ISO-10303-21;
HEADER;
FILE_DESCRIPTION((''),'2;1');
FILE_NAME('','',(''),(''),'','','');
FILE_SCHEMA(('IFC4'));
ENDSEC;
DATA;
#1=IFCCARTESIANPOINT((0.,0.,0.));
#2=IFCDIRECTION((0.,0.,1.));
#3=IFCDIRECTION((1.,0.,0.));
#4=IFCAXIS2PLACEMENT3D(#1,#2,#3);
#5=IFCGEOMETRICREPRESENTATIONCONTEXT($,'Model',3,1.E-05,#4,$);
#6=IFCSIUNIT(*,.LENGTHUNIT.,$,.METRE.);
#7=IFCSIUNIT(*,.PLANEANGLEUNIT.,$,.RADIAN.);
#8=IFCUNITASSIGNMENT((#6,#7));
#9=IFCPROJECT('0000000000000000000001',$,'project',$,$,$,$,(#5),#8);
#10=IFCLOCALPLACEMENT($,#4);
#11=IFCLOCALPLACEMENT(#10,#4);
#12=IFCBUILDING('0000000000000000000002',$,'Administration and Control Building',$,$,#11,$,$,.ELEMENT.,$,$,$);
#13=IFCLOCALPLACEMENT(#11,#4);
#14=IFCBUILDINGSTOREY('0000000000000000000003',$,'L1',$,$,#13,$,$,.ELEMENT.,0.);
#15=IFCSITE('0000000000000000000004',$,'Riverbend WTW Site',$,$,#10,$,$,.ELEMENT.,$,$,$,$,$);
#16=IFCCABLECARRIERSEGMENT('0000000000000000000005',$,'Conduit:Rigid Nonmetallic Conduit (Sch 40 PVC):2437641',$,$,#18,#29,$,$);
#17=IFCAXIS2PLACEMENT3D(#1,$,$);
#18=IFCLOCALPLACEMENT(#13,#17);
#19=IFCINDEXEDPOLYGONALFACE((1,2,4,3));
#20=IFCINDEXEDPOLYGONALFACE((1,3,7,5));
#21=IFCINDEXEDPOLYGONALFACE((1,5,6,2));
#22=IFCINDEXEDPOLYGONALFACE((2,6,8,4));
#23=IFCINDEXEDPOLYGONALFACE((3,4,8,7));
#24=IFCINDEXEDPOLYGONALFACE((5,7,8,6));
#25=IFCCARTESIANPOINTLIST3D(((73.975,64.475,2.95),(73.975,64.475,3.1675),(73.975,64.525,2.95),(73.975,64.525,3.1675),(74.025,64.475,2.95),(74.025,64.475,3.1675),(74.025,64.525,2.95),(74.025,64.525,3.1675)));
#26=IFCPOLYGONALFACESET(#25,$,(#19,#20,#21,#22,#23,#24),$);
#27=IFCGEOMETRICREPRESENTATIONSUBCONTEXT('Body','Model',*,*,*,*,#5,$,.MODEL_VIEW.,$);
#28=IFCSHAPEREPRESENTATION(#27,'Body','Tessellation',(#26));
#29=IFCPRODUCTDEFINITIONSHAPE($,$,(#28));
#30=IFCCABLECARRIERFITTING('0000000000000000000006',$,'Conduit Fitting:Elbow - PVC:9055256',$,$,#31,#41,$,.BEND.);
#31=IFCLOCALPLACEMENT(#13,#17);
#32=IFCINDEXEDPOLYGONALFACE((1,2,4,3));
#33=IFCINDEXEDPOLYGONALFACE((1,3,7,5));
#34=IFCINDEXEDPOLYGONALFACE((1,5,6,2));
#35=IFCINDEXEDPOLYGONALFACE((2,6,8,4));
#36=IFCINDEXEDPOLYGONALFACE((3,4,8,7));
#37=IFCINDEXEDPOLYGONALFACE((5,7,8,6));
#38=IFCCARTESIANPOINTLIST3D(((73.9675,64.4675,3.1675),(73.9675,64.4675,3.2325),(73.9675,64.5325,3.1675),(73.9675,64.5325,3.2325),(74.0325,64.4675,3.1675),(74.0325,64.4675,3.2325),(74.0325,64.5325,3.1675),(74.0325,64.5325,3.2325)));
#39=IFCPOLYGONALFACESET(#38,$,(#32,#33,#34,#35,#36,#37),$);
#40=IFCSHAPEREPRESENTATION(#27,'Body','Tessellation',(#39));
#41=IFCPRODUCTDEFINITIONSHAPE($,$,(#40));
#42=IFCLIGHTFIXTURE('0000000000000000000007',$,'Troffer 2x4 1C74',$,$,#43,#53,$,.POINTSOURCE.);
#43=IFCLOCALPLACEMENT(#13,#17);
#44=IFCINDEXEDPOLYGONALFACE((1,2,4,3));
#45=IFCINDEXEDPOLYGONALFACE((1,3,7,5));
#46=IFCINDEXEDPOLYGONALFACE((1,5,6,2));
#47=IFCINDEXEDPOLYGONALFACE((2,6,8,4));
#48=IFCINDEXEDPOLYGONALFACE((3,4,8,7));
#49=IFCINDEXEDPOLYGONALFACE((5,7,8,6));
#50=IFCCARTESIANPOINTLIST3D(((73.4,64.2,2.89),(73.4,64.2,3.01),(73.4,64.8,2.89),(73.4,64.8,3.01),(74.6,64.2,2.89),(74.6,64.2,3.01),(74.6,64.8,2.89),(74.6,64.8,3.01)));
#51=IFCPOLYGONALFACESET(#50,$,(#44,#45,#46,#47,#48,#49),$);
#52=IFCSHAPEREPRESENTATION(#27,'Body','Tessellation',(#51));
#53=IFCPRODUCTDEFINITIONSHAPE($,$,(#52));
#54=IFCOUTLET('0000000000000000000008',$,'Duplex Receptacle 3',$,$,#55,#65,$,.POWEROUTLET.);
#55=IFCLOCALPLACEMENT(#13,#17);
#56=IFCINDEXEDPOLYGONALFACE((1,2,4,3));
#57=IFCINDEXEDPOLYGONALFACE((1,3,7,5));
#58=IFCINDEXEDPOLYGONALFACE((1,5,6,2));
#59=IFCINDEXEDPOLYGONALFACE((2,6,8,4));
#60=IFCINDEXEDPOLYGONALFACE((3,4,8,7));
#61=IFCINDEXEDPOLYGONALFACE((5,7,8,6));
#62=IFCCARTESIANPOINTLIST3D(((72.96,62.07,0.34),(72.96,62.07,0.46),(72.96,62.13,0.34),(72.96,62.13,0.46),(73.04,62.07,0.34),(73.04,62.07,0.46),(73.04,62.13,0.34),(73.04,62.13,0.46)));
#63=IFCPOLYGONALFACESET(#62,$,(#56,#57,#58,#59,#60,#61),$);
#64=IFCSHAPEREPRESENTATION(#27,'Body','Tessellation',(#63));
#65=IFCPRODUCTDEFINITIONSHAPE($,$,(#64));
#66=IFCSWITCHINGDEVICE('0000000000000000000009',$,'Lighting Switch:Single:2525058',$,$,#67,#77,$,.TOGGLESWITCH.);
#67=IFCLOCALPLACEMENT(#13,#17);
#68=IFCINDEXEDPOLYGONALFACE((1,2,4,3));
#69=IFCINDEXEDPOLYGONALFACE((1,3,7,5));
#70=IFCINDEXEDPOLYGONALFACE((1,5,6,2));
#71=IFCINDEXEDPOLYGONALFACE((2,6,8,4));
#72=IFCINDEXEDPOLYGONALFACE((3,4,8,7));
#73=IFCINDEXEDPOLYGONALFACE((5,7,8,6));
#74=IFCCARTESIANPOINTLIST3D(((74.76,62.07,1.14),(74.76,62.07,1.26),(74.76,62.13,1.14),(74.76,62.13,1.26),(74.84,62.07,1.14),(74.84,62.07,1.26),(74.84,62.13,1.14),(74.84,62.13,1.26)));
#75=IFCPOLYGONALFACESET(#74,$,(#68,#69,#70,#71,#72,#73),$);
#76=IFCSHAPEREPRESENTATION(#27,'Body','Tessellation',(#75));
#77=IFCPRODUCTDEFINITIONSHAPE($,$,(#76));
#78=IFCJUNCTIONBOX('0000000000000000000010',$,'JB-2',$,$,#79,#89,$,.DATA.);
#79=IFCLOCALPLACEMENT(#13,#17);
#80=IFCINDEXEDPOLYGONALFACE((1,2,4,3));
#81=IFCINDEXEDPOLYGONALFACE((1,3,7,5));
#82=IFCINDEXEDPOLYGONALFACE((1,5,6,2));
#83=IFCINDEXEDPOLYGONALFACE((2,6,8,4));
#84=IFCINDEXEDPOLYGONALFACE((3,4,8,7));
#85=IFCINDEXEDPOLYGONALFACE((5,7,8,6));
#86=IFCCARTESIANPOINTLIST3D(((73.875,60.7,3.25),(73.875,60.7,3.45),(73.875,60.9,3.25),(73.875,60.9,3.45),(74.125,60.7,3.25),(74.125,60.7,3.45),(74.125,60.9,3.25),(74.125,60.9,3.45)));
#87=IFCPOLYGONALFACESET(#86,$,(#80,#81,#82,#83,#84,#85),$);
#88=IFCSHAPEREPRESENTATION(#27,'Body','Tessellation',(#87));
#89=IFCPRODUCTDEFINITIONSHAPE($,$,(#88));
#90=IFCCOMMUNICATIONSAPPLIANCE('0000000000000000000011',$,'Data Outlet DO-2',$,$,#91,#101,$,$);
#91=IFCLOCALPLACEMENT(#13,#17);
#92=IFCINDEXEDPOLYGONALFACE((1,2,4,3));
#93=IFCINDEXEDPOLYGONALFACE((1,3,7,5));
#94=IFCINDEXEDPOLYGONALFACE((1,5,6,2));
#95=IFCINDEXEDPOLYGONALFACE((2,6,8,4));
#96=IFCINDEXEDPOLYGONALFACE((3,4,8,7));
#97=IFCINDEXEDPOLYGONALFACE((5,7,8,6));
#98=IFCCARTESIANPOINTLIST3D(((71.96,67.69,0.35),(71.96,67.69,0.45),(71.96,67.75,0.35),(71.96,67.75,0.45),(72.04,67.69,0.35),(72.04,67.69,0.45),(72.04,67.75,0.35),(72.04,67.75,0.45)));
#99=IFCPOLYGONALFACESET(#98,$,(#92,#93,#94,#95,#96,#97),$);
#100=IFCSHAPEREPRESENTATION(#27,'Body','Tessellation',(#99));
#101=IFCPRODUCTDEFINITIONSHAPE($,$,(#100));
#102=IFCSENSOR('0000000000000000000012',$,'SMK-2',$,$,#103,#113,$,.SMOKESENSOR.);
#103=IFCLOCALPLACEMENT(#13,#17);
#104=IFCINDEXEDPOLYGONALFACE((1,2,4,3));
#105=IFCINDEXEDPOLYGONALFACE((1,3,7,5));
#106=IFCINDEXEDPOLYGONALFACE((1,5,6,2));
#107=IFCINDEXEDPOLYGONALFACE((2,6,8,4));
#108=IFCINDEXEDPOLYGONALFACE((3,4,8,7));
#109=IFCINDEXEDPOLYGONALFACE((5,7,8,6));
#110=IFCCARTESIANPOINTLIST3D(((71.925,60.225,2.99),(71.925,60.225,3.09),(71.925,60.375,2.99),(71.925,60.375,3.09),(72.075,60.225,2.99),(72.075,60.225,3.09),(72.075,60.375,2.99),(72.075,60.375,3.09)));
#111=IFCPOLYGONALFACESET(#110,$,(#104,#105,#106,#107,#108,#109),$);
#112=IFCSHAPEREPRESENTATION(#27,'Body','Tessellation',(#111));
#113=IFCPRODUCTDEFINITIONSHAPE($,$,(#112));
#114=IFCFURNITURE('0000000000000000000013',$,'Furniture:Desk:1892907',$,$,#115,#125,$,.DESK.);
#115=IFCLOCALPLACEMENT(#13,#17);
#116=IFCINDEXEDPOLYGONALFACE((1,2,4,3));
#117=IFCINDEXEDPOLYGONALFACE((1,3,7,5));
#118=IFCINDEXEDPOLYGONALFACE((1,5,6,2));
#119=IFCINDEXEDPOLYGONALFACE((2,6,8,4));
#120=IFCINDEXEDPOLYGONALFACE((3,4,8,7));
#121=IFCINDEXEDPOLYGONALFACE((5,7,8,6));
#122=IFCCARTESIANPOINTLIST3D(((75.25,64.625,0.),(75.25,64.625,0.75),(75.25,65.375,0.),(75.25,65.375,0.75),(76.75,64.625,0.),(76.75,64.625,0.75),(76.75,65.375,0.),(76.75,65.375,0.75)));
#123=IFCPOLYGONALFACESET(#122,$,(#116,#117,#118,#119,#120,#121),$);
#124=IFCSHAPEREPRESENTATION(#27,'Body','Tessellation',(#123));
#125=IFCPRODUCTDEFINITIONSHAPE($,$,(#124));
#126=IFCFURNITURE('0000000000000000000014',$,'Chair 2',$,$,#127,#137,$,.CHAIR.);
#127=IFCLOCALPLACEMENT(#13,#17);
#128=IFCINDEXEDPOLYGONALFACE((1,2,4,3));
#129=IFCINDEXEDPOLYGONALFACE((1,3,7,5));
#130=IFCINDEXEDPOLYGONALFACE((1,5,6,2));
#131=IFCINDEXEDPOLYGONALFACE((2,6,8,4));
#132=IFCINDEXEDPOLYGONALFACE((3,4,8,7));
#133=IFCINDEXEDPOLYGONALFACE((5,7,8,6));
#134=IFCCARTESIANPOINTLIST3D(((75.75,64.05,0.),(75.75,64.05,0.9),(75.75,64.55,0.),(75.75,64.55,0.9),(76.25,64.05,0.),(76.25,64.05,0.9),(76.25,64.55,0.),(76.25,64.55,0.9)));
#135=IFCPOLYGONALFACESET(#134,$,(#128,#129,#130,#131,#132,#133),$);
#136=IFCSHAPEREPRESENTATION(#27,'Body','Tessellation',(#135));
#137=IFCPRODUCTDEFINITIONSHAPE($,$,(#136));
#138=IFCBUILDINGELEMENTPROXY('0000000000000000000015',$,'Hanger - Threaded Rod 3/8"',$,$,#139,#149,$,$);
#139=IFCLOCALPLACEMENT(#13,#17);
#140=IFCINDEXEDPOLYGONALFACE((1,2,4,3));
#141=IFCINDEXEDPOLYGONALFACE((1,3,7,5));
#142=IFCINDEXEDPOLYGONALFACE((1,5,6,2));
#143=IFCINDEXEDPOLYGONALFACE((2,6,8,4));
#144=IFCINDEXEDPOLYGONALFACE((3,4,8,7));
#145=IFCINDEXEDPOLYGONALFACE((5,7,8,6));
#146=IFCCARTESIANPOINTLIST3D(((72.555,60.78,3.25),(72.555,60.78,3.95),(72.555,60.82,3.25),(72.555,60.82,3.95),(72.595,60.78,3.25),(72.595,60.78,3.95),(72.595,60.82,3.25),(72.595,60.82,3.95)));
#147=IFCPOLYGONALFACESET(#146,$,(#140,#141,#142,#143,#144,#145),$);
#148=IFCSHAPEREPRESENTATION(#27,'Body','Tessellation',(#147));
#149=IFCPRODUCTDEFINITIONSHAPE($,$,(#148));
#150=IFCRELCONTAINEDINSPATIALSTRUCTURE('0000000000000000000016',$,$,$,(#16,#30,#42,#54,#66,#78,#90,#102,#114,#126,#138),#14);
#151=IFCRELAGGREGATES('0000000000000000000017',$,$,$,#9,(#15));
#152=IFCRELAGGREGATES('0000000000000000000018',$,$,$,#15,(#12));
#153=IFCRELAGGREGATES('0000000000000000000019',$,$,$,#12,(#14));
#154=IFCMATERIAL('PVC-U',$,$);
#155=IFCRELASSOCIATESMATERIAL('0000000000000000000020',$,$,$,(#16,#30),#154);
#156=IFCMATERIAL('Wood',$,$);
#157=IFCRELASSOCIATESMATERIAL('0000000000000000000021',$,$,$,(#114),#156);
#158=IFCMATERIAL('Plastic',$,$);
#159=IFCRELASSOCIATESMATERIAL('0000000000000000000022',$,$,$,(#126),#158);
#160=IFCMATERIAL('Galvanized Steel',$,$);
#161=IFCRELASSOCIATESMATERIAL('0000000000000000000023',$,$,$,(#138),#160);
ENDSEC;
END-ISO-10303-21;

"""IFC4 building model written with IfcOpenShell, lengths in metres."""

from ifc_helpers import new_model, si_unit, frame, origin_with_axes, origin_2d, place, context, subcontext, project, spatial, rectangle, extrude, material, element, save


model = new_model("IFC4")

# Units and contexts
model_context = context("Model", 3, precision=1e-05, world=origin_with_axes())
body_context = subcontext(model_context, "Body", "Model", "MODEL_VIEW")
ifc_project = project(units=[si_unit("LENGTHUNIT", "METRE"), si_unit("PLANEANGLEUNIT", "RADIAN")], contexts=[model_context])

# Site, building, storey
site_placement = place(None, origin_with_axes())
site = spatial("IfcSite", under=ifc_project, at=site_placement, Name="Riverbend WTW Site", CompositionType="ELEMENT")
building_placement = place(site_placement, origin_with_axes())
building = spatial("IfcBuilding", under=site, at=building_placement, Name="Administration and Control Building", CompositionType="ELEMENT")
storey_placement = place(building_placement, origin_with_axes())
storey = spatial("IfcBuildingStorey", under=building, at=storey_placement, Name="L1", CompositionType="ELEMENT", Elevation=0.0)

# Shared definitions
ifc_material_1 = material(Name="Galvanized Steel")

# Cable carrier segment
ifc_material_2 = material(Name="PVC-U")
cable_carrier_segment_1_placement = place(None, frame((74.0, 64.5, 3.0587), z_axis=(0.0, 0.0, 1.0), x_axis=(1.0, 0.0, 0.0)))
element("IfcCableCarrierSegment", 1, at=cable_carrier_segment_1_placement, inside=storey, material=ifc_material_2, Name="Conduit:Rigid Nonmetallic Conduit (Sch 40 PVC):2437641", context=body_context, shape_type="SweptSolid", body=[
    extrude(rectangle(XDim=0.05, YDim=0.05, at=origin_2d()), frame((0.0, 0.0, -0.1087), z_axis=(0.0, 0.0, 1.0), x_axis=(1.0, 0.0, 0.0)), (0.0, 0.0, 1.0), 0.2175),
])

# Cable carrier fitting
cable_carrier_fitting_1_placement = place(None, frame((74.0, 64.5, 3.2), z_axis=(0.0, 0.0, 1.0), x_axis=(1.0, 0.0, 0.0)))
element("IfcCableCarrierFitting", 2, at=cable_carrier_fitting_1_placement, inside=storey, material=ifc_material_2, Name="Conduit Fitting:Elbow - PVC:9055256", PredefinedType="BEND", context=body_context, shape_type="SweptSolid", body=[
    extrude(rectangle(XDim=0.065, YDim=0.065, at=origin_2d()), frame((0.0, 0.0, -0.0325), z_axis=(0.0, 0.0, 1.0), x_axis=(1.0, 0.0, 0.0)), (0.0, 0.0, 1.0), 0.065),
])

# Light fixture
light_fixture_placement = place(None, frame((74.0, 64.5, 2.95), z_axis=(0.0, 0.0, 1.0), x_axis=(1.0, 0.0, 0.0)))
element("IfcLightFixture", 3, at=light_fixture_placement, inside=storey, Name="Troffer 2x4 1C74", PredefinedType="POINTSOURCE", context=body_context, shape_type="SweptSolid", body=[
    extrude(rectangle(XDim=1.2, YDim=0.6, at=origin_2d()), frame((0.0, 0.0, -0.06), z_axis=(0.0, 0.0, 1.0), x_axis=(1.0, 0.0, 0.0)), (0.0, 0.0, 1.0), 0.12),
])

# Outlet
outlet_placement = place(None, frame((73.0, 62.1, 0.4), z_axis=(0.0, 0.0, 1.0), x_axis=(1.0, 0.0, 0.0)))
element("IfcOutlet", 4, at=outlet_placement, inside=storey, Name="Duplex Receptacle 3", PredefinedType="POWEROUTLET", context=body_context, shape_type="SweptSolid", body=[
    extrude(rectangle(XDim=0.08, YDim=0.06, at=origin_2d()), frame((0.0, 0.0, -0.06), z_axis=(0.0, 0.0, 1.0), x_axis=(1.0, 0.0, 0.0)), (0.0, 0.0, 1.0), 0.12),
])

# Switching device
switching_device_placement = place(None, frame((74.8, 62.1, 1.2), z_axis=(0.0, 0.0, 1.0), x_axis=(1.0, 0.0, 0.0)))
element("IfcSwitchingDevice", 5, at=switching_device_placement, inside=storey, Name="Lighting Switch:Single:2525058", PredefinedType="TOGGLESWITCH", context=body_context, shape_type="SweptSolid", body=[
    extrude(rectangle(XDim=0.08, YDim=0.06, at=origin_2d()), frame((0.0, 0.0, -0.06), z_axis=(0.0, 0.0, 1.0), x_axis=(1.0, 0.0, 0.0)), (0.0, 0.0, 1.0), 0.12),
])

# Junction box
junction_box_placement = place(None, frame((74.0, 60.8, 3.35), z_axis=(0.0, 0.0, 1.0), x_axis=(1.0, 0.0, 0.0)))
element("IfcJunctionBox", 6, at=junction_box_placement, inside=storey, Name="JB-2", PredefinedType="DATA", context=body_context, shape_type="SweptSolid", body=[
    extrude(rectangle(XDim=0.25, YDim=0.2, at=origin_2d()), frame((0.0, 0.0, -0.1), z_axis=(0.0, 0.0, 1.0), x_axis=(1.0, 0.0, 0.0)), (0.0, 0.0, 1.0), 0.2),
])

# Communications appliance
communications_appliance_placement = place(None, frame((72.0, 67.72, 0.4), z_axis=(0.0, 0.0, 1.0), x_axis=(1.0, 0.0, 0.0)))
element("IfcCommunicationsAppliance", 7, at=communications_appliance_placement, inside=storey, Name="Data Outlet DO-2", context=body_context, shape_type="SweptSolid", body=[
    extrude(rectangle(XDim=0.08, YDim=0.06, at=origin_2d()), frame((0.0, 0.0, -0.05), z_axis=(0.0, 0.0, 1.0), x_axis=(1.0, 0.0, 0.0)), (0.0, 0.0, 1.0), 0.1),
])

# Sensor
sensor_placement = place(None, frame((72.0, 60.3, 3.04), z_axis=(0.0, 0.0, 1.0), x_axis=(1.0, 0.0, 0.0)))
element("IfcSensor", 8, at=sensor_placement, inside=storey, Name="SMK-2", PredefinedType="SMOKESENSOR", context=body_context, shape_type="SweptSolid", body=[
    extrude(rectangle(XDim=0.15, YDim=0.15, at=origin_2d()), frame((0.0, 0.0, -0.05), z_axis=(0.0, 0.0, 1.0), x_axis=(1.0, 0.0, 0.0)), (0.0, 0.0, 1.0), 0.1),
])

# Furniture
ifc_material_3 = material(Name="Wood")
furniture_1_placement = place(None, frame((76.0, 65.0, 0.375), z_axis=(0.0, 0.0, 1.0), x_axis=(1.0, 0.0, 0.0)))
element("IfcFurniture", 9, at=furniture_1_placement, inside=storey, material=ifc_material_3, Name="Furniture:Desk:1892907", PredefinedType="DESK", context=body_context, shape_type="SweptSolid", body=[
    extrude(rectangle(XDim=1.5, YDim=0.75, at=origin_2d()), frame((0.0, 0.0, -0.375), z_axis=(0.0, 0.0, 1.0), x_axis=(1.0, 0.0, 0.0)), (0.0, 0.0, 1.0), 0.75),
])
ifc_material_4 = material(Name="Plastic")
furniture_2_placement = place(None, frame((76.0, 64.3, 0.45), z_axis=(0.0, 0.0, 1.0), x_axis=(1.0, 0.0, 0.0)))
element("IfcFurniture", 10, at=furniture_2_placement, inside=storey, material=ifc_material_4, Name="Chair 2", PredefinedType="CHAIR", context=body_context, shape_type="SweptSolid", body=[
    extrude(rectangle(XDim=0.5, YDim=0.5, at=origin_2d()), frame((0.0, 0.0, -0.45), z_axis=(0.0, 0.0, 1.0), x_axis=(1.0, 0.0, 0.0)), (0.0, 0.0, 1.0), 0.9),
])

# Building element proxy
proxy_placement = place(None, frame((72.575, 60.8, 3.6), z_axis=(0.0, 0.0, 1.0), x_axis=(1.0, 0.0, 0.0)))
element("IfcBuildingElementProxy", 11, at=proxy_placement, inside=storey, material=ifc_material_1, Name="Hanger - Threaded Rod 3/8\"", context=body_context, shape_type="SweptSolid", body=[
    extrude(rectangle(XDim=0.04, YDim=0.04, at=origin_2d()), frame((0.0, 0.0, -0.35), z_axis=(0.0, 0.0, 1.0), x_axis=(1.0, 0.0, 0.0)), (0.0, 0.0, 1.0), 0.7),
])

save(model, "model.ifc")
